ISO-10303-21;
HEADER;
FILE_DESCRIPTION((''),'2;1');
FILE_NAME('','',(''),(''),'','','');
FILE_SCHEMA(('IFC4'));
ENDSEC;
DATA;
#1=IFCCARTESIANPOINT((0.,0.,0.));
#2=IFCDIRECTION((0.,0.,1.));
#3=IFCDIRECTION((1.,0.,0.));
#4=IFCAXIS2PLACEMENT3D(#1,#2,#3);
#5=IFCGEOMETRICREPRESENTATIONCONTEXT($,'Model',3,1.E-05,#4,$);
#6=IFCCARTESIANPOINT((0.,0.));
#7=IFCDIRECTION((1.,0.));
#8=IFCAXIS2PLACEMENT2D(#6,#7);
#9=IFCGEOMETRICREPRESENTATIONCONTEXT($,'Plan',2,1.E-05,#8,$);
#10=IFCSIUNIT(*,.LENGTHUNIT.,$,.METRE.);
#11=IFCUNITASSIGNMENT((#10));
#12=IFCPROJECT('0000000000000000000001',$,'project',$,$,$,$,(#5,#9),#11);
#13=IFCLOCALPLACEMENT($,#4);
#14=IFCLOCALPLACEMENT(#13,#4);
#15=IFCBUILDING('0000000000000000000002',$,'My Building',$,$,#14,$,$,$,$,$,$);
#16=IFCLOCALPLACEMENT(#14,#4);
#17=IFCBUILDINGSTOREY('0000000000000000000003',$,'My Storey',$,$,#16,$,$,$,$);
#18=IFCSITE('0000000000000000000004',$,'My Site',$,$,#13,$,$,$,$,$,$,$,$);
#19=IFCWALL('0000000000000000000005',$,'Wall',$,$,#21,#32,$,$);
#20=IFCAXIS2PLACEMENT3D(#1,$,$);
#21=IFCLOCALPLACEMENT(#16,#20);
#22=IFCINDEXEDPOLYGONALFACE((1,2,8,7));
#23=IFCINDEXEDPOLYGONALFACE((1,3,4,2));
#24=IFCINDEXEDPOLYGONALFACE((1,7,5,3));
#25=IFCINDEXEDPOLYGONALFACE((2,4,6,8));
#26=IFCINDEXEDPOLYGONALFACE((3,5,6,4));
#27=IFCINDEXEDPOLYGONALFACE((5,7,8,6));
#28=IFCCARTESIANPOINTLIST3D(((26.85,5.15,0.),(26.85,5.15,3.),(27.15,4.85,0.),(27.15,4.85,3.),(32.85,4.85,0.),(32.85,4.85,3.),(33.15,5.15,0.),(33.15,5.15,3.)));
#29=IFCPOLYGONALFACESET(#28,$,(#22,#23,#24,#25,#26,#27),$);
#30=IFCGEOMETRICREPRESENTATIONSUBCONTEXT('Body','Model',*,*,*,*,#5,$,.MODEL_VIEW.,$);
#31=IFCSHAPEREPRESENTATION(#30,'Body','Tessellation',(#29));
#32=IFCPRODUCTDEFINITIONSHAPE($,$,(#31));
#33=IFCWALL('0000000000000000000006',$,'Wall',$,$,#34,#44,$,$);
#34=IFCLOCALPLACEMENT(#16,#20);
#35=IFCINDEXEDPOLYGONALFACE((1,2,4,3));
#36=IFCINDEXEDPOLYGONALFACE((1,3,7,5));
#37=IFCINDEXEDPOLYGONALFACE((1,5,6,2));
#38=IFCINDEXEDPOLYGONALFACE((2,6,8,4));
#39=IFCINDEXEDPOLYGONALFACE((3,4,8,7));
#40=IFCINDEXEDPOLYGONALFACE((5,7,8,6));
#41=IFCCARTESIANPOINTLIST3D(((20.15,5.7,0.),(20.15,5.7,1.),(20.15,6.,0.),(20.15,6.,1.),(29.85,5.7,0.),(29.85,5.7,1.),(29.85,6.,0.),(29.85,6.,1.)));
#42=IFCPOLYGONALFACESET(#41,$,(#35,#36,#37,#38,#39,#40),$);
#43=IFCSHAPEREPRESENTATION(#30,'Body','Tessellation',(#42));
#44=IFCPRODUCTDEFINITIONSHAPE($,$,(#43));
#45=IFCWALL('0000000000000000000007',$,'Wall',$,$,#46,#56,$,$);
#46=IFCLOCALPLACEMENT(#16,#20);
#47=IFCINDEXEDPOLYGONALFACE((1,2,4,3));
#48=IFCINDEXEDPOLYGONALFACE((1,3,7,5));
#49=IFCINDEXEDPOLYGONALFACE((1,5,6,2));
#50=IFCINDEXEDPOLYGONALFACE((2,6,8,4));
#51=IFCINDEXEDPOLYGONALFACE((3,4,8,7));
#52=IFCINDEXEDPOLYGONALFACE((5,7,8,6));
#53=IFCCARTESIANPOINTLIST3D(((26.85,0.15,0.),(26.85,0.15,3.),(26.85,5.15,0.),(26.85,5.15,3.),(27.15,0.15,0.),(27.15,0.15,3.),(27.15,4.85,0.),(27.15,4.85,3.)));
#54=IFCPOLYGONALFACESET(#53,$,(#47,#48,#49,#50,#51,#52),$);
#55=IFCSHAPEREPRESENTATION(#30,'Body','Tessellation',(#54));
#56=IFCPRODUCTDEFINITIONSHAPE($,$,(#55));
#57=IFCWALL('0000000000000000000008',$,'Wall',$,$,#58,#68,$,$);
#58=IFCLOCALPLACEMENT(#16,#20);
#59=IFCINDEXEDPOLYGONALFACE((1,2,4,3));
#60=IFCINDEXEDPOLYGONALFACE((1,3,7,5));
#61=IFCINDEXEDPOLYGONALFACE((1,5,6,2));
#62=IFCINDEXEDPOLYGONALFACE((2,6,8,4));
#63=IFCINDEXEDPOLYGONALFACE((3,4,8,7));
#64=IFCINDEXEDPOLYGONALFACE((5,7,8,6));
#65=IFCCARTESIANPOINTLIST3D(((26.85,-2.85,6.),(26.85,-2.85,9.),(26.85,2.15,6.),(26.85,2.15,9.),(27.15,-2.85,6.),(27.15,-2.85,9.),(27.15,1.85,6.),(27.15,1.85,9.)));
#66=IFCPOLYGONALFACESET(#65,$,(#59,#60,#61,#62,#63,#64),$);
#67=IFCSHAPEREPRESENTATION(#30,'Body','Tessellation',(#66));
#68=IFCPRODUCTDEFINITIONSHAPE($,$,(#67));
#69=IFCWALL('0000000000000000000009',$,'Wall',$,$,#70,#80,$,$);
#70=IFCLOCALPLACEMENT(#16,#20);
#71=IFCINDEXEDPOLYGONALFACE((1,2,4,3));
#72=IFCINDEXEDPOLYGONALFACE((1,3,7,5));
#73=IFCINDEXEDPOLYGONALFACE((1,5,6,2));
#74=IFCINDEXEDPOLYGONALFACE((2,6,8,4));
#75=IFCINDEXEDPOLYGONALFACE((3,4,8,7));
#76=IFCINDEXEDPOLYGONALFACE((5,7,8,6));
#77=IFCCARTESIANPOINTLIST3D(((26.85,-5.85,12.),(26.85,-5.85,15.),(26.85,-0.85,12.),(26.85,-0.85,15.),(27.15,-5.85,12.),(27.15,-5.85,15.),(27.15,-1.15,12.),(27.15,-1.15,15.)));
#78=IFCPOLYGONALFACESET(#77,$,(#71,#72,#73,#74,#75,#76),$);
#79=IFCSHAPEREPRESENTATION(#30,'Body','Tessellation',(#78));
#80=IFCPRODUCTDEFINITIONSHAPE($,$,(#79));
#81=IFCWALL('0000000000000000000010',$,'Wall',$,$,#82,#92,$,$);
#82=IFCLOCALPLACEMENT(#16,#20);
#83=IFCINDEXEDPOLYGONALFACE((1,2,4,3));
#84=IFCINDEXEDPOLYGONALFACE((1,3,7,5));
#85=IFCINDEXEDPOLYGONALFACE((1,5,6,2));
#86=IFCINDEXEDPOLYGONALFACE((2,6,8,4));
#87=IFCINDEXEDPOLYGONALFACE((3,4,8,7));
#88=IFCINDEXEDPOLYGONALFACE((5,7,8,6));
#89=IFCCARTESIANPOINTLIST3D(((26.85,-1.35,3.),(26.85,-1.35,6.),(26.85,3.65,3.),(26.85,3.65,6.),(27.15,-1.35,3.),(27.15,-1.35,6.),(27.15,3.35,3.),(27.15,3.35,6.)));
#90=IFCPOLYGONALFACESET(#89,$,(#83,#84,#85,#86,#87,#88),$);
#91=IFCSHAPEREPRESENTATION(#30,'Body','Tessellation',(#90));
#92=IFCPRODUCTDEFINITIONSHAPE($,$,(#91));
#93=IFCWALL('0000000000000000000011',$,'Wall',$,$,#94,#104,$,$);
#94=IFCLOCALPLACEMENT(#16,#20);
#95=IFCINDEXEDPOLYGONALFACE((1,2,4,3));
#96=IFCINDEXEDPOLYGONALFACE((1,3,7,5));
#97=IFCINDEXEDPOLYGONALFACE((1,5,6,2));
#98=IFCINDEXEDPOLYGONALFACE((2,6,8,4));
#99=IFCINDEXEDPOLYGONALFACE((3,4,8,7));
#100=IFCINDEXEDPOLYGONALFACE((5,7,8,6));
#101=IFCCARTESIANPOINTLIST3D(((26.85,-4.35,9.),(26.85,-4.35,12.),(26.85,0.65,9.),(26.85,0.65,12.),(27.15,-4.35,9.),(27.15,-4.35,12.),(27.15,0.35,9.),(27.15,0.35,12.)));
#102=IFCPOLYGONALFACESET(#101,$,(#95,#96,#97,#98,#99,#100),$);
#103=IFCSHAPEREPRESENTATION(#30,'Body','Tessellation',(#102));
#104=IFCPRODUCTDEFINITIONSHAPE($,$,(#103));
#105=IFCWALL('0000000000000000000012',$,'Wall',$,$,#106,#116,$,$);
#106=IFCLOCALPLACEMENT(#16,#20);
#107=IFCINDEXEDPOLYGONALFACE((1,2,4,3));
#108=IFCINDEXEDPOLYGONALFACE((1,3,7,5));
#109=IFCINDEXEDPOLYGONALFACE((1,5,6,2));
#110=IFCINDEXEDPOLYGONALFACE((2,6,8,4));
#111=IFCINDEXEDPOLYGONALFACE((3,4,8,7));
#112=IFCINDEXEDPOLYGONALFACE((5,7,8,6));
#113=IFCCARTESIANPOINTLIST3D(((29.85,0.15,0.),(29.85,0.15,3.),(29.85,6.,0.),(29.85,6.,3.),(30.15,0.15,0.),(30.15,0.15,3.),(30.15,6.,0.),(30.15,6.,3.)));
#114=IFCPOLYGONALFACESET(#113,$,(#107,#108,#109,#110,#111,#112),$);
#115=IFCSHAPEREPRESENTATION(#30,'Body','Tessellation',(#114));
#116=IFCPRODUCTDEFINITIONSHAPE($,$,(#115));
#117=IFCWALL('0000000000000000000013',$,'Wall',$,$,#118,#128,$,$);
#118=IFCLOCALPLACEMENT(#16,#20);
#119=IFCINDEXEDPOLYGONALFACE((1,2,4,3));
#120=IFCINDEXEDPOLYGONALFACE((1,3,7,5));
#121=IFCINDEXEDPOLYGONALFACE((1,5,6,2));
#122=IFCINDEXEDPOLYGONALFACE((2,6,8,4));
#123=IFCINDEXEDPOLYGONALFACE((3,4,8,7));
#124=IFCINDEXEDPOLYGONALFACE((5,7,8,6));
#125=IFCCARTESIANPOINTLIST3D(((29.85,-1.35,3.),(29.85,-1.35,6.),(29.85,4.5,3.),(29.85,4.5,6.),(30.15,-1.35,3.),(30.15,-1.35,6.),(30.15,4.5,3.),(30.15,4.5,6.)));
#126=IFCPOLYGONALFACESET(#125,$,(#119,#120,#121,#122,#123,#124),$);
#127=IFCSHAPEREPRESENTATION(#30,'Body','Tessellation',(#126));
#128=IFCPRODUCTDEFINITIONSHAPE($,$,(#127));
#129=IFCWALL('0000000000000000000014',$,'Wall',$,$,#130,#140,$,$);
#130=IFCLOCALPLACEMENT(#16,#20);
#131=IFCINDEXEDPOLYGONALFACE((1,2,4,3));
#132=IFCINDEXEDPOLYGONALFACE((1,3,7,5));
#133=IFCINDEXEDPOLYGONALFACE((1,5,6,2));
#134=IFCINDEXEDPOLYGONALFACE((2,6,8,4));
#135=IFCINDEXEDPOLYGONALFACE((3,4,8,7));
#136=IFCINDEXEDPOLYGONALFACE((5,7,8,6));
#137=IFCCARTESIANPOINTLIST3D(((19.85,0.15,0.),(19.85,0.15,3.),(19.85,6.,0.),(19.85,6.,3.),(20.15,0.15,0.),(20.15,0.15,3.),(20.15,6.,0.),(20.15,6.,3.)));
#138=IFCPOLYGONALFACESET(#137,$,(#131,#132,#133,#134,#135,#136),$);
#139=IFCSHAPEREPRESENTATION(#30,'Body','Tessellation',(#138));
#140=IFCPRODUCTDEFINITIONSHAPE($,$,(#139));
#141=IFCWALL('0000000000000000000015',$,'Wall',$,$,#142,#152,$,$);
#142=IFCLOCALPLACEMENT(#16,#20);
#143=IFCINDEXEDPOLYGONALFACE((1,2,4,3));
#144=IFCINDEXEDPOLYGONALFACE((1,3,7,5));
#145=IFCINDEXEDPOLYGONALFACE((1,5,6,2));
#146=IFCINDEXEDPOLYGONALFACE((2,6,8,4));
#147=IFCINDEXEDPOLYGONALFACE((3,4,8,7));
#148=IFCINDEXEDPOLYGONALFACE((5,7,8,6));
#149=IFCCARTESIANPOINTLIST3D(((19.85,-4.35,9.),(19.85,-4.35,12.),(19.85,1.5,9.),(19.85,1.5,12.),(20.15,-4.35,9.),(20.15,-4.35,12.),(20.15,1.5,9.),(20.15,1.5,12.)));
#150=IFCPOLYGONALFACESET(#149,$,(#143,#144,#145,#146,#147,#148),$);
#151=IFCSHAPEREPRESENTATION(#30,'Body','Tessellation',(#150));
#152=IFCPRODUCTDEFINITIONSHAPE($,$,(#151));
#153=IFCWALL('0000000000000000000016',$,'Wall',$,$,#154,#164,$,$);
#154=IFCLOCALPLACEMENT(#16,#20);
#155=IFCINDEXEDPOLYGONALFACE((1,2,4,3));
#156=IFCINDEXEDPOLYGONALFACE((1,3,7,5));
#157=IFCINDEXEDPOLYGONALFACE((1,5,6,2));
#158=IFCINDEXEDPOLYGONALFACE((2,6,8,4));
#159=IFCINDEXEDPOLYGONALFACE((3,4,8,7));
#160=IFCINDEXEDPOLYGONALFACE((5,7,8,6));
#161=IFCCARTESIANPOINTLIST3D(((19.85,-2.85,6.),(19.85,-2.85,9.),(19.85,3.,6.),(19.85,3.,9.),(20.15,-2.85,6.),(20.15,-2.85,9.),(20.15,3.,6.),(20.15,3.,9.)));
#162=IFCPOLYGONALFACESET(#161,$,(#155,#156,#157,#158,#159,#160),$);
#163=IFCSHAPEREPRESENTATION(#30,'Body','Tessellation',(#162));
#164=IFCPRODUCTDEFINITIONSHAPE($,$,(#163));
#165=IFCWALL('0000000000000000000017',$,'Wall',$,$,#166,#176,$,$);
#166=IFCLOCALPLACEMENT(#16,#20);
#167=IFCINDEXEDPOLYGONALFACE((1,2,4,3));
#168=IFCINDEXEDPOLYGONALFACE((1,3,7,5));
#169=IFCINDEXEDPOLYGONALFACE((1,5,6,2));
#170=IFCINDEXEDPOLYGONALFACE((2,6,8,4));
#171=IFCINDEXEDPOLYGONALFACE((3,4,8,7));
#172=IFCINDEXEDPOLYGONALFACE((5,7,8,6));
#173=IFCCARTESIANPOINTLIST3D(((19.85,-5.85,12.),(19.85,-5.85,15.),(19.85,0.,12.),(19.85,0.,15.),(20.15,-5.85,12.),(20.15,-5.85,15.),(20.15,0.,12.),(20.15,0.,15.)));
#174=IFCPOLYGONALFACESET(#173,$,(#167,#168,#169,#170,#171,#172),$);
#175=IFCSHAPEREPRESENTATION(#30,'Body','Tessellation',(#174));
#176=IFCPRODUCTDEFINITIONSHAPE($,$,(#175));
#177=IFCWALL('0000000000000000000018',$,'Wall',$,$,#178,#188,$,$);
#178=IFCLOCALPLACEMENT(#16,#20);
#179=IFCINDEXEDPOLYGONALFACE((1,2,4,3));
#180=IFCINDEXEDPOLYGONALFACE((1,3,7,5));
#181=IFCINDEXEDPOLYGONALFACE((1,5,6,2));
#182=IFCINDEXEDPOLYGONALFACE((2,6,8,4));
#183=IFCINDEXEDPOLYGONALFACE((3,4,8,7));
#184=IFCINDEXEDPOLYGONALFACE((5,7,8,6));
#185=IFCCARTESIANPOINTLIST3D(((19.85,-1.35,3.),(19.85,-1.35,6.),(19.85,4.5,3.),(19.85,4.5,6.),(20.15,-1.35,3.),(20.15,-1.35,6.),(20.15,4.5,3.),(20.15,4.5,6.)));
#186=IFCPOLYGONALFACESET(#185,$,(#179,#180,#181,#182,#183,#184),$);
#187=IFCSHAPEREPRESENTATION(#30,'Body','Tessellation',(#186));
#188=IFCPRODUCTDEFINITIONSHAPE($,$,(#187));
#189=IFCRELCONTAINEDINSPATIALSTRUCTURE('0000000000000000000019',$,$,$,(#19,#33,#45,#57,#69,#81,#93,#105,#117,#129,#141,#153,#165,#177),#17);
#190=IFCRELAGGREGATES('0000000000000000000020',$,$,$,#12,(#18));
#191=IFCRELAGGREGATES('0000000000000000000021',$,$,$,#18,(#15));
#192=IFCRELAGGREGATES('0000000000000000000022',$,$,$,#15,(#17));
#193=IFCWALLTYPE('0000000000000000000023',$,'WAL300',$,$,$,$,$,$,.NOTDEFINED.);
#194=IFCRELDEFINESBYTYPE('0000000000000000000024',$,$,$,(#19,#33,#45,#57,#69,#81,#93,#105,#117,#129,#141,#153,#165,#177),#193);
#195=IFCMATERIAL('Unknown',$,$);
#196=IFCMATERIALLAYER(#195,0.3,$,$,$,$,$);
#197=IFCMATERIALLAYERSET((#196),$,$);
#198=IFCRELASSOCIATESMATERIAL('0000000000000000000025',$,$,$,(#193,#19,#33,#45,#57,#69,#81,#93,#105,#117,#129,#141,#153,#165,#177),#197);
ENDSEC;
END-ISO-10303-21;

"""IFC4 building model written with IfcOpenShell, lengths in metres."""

from ifc_helpers import new_model, si_unit, frame, origin_with_axes, origin_2d_with_axis, place, context, subcontext, project, spatial, line, indexed_curve, outline, extrude, material, layer, layer_set, layer_usage, type_object, element, save


model = new_model("IFC4")

# Units and contexts
model_context = context("Model", 3, precision=1e-05, world=origin_with_axes())
plan_context = context("Plan", 2, precision=1e-05, world=origin_2d_with_axis())
body_context = subcontext(model_context, "Body", "Model", "MODEL_VIEW")
ifc_project = project(units=[si_unit("LENGTHUNIT", "METRE")], contexts=[model_context, plan_context])

# Site, building, storey
site_placement = place(None, origin_with_axes())
site = spatial("IfcSite", under=ifc_project, at=site_placement, Name="My Site")
building_placement = place(site_placement, origin_with_axes())
building = spatial("IfcBuilding", under=site, at=building_placement, Name="My Building")
storey_placement = place(building_placement, origin_with_axes())
storey = spatial("IfcBuildingStorey", under=building, at=storey_placement, Name="My Storey")

# Walls
ifc_material = material(Name="Unknown")
ifc_layer = layer(ifc_material, 0.3)
ifc_layer_set = layer_set([ifc_layer])
ifc_layer_usage_1 = layer_usage(ifc_layer_set, "AXIS2", "POSITIVE", -0.15)
wall_type = type_object("IfcWallType", Name="WAL300", PredefinedType="NOTDEFINED", material=ifc_layer_set)
wall_1_placement = place(storey_placement, frame((27.0, 5.0, 0.0), z_axis=(0.0, 0.0, 1.0), x_axis=(1.0, 0.0, 0.0)))
element("IfcWall", 1, at=wall_1_placement, inside=storey, type_object=wall_type, material=ifc_layer_usage_1, Name="Wall", context=body_context, shape_type="SweptSolid", body=[
    extrude(outline(indexed_curve([(0.15, -0.15), (-0.15, 0.15), (6.15, 0.15), (5.85, -0.15)], segments=[line(1, 2, 3, 4, 1)])), origin_with_axes(), (0.0, 0.0, 1.0), 3.0),
])
ifc_layer_usage_2 = layer_usage(ifc_layer_set, "AXIS2", "POSITIVE", -0.3)
wall_2_placement = place(storey_placement, frame((20.15, 6.0, 0.0), z_axis=(0.0, 0.0, 1.0), x_axis=(1.0, 0.0, 0.0)))
element("IfcWall", 2, at=wall_2_placement, inside=storey, type_object=wall_type, material=ifc_layer_usage_2, Name="Wall", context=body_context, shape_type="SweptSolid", body=[
    extrude(outline(indexed_curve([(0.0, -0.3), (0.0, 0.0), (9.7, 0.0), (9.7, -0.3)], segments=[line(1, 2, 3, 4, 1)])), origin_with_axes(), (0.0, 0.0, 1.0), 1.0),
])
ifc_layer_usage_3 = layer_usage(ifc_layer_set, "AXIS2", "POSITIVE", -0.15)
wall_3_placement = place(storey_placement, frame((27.0, 5.0, 0.0), z_axis=(0.0, 0.0, 1.0), x_axis=(0.0, -1.0, 0.0)))
element("IfcWall", 3, at=wall_3_placement, inside=storey, type_object=wall_type, material=ifc_layer_usage_3, Name="Wall", context=body_context, shape_type="SweptSolid", body=[
    extrude(outline(indexed_curve([(-0.15, -0.15), (0.15, 0.15), (4.85, 0.15), (4.85, -0.15)], segments=[line(1, 2, 3, 4, 1)])), origin_with_axes(), (0.0, 0.0, 1.0), 3.0),
])
ifc_layer_usage_4 = layer_usage(ifc_layer_set, "AXIS2", "POSITIVE", -0.15)
wall_4_placement = place(storey_placement, frame((27.0, 2.0, 6.0), z_axis=(0.0, 0.0, 1.0), x_axis=(0.0, -1.0, 0.0)))
element("IfcWall", 4, at=wall_4_placement, inside=storey, type_object=wall_type, material=ifc_layer_usage_4, Name="Wall", context=body_context, shape_type="SweptSolid", body=[
    extrude(outline(indexed_curve([(-0.15, -0.15), (0.15, 0.15), (4.85, 0.15), (4.85, -0.15)], segments=[line(1, 2, 3, 4, 1)])), origin_with_axes(), (0.0, 0.0, 1.0), 3.0),
])
ifc_layer_usage_5 = layer_usage(ifc_layer_set, "AXIS2", "POSITIVE", -0.15)
wall_5_placement = place(storey_placement, frame((27.0, -1.0, 12.0), z_axis=(0.0, 0.0, 1.0), x_axis=(0.0, -1.0, 0.0)))
element("IfcWall", 5, at=wall_5_placement, inside=storey, type_object=wall_type, material=ifc_layer_usage_5, Name="Wall", context=body_context, shape_type="SweptSolid", body=[
    extrude(outline(indexed_curve([(-0.15, -0.15), (0.15, 0.15), (4.85, 0.15), (4.85, -0.15)], segments=[line(1, 2, 3, 4, 1)])), origin_with_axes(), (0.0, 0.0, 1.0), 3.0),
])
ifc_layer_usage_6 = layer_usage(ifc_layer_set, "AXIS2", "POSITIVE", -0.15)
wall_6_placement = place(storey_placement, frame((27.0, 3.5, 3.0), z_axis=(0.0, 0.0, 1.0), x_axis=(0.0, -1.0, 0.0)))
element("IfcWall", 6, at=wall_6_placement, inside=storey, type_object=wall_type, material=ifc_layer_usage_6, Name="Wall", context=body_context, shape_type="SweptSolid", body=[
    extrude(outline(indexed_curve([(-0.15, -0.15), (0.15, 0.15), (4.85, 0.15), (4.85, -0.15)], segments=[line(1, 2, 3, 4, 1)])), origin_with_axes(), (0.0, 0.0, 1.0), 3.0),
])
ifc_layer_usage_7 = layer_usage(ifc_layer_set, "AXIS2", "POSITIVE", -0.15)
wall_7_placement = place(storey_placement, frame((27.0, 0.5, 9.0), z_axis=(0.0, 0.0, 1.0), x_axis=(0.0, -1.0, 0.0)))
element("IfcWall", 7, at=wall_7_placement, inside=storey, type_object=wall_type, material=ifc_layer_usage_7, Name="Wall", context=body_context, shape_type="SweptSolid", body=[
    extrude(outline(indexed_curve([(-0.15, -0.15), (0.15, 0.15), (4.85, 0.15), (4.85, -0.15)], segments=[line(1, 2, 3, 4, 1)])), origin_with_axes(), (0.0, 0.0, 1.0), 3.0),
])
ifc_layer_usage_8 = layer_usage(ifc_layer_set, "AXIS2", "POSITIVE", -0.15)
wall_8_placement = place(storey_placement, frame((30.0, 6.0, 0.0), z_axis=(0.0, 0.0, 1.0), x_axis=(0.0, -1.0, 0.0)))
element("IfcWall", 8, at=wall_8_placement, inside=storey, type_object=wall_type, material=ifc_layer_usage_8, Name="Wall", context=body_context, shape_type="SweptSolid", body=[
    extrude(outline(indexed_curve([(0.0, -0.15), (0.0, 0.15), (5.85, 0.15), (5.85, -0.15)], segments=[line(1, 2, 3, 4, 1)])), origin_with_axes(), (0.0, 0.0, 1.0), 3.0),
])
ifc_layer_usage_9 = layer_usage(ifc_layer_set, "AXIS2", "POSITIVE", -0.15)
wall_9_placement = place(storey_placement, frame((30.0, 4.5, 3.0), z_axis=(0.0, 0.0, 1.0), x_axis=(0.0, -1.0, 0.0)))
element("IfcWall", 9, at=wall_9_placement, inside=storey, type_object=wall_type, material=ifc_layer_usage_9, Name="Wall", context=body_context, shape_type="SweptSolid", body=[
    extrude(outline(indexed_curve([(0.0, -0.15), (0.0, 0.15), (5.85, 0.15), (5.85, -0.15)], segments=[line(1, 2, 3, 4, 1)])), origin_with_axes(), (0.0, 0.0, 1.0), 3.0),
])
ifc_layer_usage_10 = layer_usage(ifc_layer_set, "AXIS2", "POSITIVE", -0.15)
wall_10_placement = place(storey_placement, frame((20.0, 0.0, 0.0), z_axis=(0.0, 0.0, 1.0), x_axis=(0.0, 1.0, 0.0)))
element("IfcWall", 10, at=wall_10_placement, inside=storey, type_object=wall_type, material=ifc_layer_usage_10, Name="Wall", context=body_context, shape_type="SweptSolid", body=[
    extrude(outline(indexed_curve([(0.15, -0.15), (0.15, 0.15), (6.0, 0.15), (6.0, -0.15)], segments=[line(1, 2, 3, 4, 1)])), origin_with_axes(), (0.0, 0.0, 1.0), 3.0),
])
ifc_layer_usage_11 = layer_usage(ifc_layer_set, "AXIS2", "POSITIVE", -0.15)
wall_11_placement = place(storey_placement, frame((20.0, -4.5, 9.0), z_axis=(0.0, 0.0, 1.0), x_axis=(0.0, 1.0, 0.0)))
element("IfcWall", 11, at=wall_11_placement, inside=storey, type_object=wall_type, material=ifc_layer_usage_11, Name="Wall", context=body_context, shape_type="SweptSolid", body=[
    extrude(outline(indexed_curve([(0.15, -0.15), (0.15, 0.15), (6.0, 0.15), (6.0, -0.15)], segments=[line(1, 2, 3, 4, 1)])), origin_with_axes(), (0.0, 0.0, 1.0), 3.0),
])
ifc_layer_usage_12 = layer_usage(ifc_layer_set, "AXIS2", "POSITIVE", -0.15)
wall_12_placement = place(storey_placement, frame((20.0, -3.0, 6.0), z_axis=(0.0, 0.0, 1.0), x_axis=(0.0, 1.0, 0.0)))
element("IfcWall", 12, at=wall_12_placement, inside=storey, type_object=wall_type, material=ifc_layer_usage_12, Name="Wall", context=body_context, shape_type="SweptSolid", body=[
    extrude(outline(indexed_curve([(0.15, -0.15), (0.15, 0.15), (6.0, 0.15), (6.0, -0.15)], segments=[line(1, 2, 3, 4, 1)])), origin_with_axes(), (0.0, 0.0, 1.0), 3.0),
])
ifc_layer_usage_13 = layer_usage(ifc_layer_set, "AXIS2", "POSITIVE", -0.15)
wall_13_placement = place(storey_placement, frame((20.0, -6.0, 12.0), z_axis=(0.0, 0.0, 1.0), x_axis=(0.0, 1.0, 0.0)))
element("IfcWall", 13, at=wall_13_placement, inside=storey, type_object=wall_type, material=ifc_layer_usage_13, Name="Wall", context=body_context, shape_type="SweptSolid", body=[
    extrude(outline(indexed_curve([(0.15, -0.15), (0.15, 0.15), (6.0, 0.15), (6.0, -0.15)], segments=[line(1, 2, 3, 4, 1)])), origin_with_axes(), (0.0, 0.0, 1.0), 3.0),
])
ifc_layer_usage_14 = layer_usage(ifc_layer_set, "AXIS2", "POSITIVE", -0.15)
wall_14_placement = place(storey_placement, frame((20.0, -1.5, 3.0), z_axis=(0.0, 0.0, 1.0), x_axis=(0.0, 1.0, 0.0)))
element("IfcWall", 14, at=wall_14_placement, inside=storey, type_object=wall_type, material=ifc_layer_usage_14, Name="Wall", context=body_context, shape_type="SweptSolid", body=[
    extrude(outline(indexed_curve([(0.15, -0.15), (0.15, 0.15), (6.0, 0.15), (6.0, -0.15)], segments=[line(1, 2, 3, 4, 1)])), origin_with_axes(), (0.0, 0.0, 1.0), 3.0),
])

save(model, "model.ifc")
